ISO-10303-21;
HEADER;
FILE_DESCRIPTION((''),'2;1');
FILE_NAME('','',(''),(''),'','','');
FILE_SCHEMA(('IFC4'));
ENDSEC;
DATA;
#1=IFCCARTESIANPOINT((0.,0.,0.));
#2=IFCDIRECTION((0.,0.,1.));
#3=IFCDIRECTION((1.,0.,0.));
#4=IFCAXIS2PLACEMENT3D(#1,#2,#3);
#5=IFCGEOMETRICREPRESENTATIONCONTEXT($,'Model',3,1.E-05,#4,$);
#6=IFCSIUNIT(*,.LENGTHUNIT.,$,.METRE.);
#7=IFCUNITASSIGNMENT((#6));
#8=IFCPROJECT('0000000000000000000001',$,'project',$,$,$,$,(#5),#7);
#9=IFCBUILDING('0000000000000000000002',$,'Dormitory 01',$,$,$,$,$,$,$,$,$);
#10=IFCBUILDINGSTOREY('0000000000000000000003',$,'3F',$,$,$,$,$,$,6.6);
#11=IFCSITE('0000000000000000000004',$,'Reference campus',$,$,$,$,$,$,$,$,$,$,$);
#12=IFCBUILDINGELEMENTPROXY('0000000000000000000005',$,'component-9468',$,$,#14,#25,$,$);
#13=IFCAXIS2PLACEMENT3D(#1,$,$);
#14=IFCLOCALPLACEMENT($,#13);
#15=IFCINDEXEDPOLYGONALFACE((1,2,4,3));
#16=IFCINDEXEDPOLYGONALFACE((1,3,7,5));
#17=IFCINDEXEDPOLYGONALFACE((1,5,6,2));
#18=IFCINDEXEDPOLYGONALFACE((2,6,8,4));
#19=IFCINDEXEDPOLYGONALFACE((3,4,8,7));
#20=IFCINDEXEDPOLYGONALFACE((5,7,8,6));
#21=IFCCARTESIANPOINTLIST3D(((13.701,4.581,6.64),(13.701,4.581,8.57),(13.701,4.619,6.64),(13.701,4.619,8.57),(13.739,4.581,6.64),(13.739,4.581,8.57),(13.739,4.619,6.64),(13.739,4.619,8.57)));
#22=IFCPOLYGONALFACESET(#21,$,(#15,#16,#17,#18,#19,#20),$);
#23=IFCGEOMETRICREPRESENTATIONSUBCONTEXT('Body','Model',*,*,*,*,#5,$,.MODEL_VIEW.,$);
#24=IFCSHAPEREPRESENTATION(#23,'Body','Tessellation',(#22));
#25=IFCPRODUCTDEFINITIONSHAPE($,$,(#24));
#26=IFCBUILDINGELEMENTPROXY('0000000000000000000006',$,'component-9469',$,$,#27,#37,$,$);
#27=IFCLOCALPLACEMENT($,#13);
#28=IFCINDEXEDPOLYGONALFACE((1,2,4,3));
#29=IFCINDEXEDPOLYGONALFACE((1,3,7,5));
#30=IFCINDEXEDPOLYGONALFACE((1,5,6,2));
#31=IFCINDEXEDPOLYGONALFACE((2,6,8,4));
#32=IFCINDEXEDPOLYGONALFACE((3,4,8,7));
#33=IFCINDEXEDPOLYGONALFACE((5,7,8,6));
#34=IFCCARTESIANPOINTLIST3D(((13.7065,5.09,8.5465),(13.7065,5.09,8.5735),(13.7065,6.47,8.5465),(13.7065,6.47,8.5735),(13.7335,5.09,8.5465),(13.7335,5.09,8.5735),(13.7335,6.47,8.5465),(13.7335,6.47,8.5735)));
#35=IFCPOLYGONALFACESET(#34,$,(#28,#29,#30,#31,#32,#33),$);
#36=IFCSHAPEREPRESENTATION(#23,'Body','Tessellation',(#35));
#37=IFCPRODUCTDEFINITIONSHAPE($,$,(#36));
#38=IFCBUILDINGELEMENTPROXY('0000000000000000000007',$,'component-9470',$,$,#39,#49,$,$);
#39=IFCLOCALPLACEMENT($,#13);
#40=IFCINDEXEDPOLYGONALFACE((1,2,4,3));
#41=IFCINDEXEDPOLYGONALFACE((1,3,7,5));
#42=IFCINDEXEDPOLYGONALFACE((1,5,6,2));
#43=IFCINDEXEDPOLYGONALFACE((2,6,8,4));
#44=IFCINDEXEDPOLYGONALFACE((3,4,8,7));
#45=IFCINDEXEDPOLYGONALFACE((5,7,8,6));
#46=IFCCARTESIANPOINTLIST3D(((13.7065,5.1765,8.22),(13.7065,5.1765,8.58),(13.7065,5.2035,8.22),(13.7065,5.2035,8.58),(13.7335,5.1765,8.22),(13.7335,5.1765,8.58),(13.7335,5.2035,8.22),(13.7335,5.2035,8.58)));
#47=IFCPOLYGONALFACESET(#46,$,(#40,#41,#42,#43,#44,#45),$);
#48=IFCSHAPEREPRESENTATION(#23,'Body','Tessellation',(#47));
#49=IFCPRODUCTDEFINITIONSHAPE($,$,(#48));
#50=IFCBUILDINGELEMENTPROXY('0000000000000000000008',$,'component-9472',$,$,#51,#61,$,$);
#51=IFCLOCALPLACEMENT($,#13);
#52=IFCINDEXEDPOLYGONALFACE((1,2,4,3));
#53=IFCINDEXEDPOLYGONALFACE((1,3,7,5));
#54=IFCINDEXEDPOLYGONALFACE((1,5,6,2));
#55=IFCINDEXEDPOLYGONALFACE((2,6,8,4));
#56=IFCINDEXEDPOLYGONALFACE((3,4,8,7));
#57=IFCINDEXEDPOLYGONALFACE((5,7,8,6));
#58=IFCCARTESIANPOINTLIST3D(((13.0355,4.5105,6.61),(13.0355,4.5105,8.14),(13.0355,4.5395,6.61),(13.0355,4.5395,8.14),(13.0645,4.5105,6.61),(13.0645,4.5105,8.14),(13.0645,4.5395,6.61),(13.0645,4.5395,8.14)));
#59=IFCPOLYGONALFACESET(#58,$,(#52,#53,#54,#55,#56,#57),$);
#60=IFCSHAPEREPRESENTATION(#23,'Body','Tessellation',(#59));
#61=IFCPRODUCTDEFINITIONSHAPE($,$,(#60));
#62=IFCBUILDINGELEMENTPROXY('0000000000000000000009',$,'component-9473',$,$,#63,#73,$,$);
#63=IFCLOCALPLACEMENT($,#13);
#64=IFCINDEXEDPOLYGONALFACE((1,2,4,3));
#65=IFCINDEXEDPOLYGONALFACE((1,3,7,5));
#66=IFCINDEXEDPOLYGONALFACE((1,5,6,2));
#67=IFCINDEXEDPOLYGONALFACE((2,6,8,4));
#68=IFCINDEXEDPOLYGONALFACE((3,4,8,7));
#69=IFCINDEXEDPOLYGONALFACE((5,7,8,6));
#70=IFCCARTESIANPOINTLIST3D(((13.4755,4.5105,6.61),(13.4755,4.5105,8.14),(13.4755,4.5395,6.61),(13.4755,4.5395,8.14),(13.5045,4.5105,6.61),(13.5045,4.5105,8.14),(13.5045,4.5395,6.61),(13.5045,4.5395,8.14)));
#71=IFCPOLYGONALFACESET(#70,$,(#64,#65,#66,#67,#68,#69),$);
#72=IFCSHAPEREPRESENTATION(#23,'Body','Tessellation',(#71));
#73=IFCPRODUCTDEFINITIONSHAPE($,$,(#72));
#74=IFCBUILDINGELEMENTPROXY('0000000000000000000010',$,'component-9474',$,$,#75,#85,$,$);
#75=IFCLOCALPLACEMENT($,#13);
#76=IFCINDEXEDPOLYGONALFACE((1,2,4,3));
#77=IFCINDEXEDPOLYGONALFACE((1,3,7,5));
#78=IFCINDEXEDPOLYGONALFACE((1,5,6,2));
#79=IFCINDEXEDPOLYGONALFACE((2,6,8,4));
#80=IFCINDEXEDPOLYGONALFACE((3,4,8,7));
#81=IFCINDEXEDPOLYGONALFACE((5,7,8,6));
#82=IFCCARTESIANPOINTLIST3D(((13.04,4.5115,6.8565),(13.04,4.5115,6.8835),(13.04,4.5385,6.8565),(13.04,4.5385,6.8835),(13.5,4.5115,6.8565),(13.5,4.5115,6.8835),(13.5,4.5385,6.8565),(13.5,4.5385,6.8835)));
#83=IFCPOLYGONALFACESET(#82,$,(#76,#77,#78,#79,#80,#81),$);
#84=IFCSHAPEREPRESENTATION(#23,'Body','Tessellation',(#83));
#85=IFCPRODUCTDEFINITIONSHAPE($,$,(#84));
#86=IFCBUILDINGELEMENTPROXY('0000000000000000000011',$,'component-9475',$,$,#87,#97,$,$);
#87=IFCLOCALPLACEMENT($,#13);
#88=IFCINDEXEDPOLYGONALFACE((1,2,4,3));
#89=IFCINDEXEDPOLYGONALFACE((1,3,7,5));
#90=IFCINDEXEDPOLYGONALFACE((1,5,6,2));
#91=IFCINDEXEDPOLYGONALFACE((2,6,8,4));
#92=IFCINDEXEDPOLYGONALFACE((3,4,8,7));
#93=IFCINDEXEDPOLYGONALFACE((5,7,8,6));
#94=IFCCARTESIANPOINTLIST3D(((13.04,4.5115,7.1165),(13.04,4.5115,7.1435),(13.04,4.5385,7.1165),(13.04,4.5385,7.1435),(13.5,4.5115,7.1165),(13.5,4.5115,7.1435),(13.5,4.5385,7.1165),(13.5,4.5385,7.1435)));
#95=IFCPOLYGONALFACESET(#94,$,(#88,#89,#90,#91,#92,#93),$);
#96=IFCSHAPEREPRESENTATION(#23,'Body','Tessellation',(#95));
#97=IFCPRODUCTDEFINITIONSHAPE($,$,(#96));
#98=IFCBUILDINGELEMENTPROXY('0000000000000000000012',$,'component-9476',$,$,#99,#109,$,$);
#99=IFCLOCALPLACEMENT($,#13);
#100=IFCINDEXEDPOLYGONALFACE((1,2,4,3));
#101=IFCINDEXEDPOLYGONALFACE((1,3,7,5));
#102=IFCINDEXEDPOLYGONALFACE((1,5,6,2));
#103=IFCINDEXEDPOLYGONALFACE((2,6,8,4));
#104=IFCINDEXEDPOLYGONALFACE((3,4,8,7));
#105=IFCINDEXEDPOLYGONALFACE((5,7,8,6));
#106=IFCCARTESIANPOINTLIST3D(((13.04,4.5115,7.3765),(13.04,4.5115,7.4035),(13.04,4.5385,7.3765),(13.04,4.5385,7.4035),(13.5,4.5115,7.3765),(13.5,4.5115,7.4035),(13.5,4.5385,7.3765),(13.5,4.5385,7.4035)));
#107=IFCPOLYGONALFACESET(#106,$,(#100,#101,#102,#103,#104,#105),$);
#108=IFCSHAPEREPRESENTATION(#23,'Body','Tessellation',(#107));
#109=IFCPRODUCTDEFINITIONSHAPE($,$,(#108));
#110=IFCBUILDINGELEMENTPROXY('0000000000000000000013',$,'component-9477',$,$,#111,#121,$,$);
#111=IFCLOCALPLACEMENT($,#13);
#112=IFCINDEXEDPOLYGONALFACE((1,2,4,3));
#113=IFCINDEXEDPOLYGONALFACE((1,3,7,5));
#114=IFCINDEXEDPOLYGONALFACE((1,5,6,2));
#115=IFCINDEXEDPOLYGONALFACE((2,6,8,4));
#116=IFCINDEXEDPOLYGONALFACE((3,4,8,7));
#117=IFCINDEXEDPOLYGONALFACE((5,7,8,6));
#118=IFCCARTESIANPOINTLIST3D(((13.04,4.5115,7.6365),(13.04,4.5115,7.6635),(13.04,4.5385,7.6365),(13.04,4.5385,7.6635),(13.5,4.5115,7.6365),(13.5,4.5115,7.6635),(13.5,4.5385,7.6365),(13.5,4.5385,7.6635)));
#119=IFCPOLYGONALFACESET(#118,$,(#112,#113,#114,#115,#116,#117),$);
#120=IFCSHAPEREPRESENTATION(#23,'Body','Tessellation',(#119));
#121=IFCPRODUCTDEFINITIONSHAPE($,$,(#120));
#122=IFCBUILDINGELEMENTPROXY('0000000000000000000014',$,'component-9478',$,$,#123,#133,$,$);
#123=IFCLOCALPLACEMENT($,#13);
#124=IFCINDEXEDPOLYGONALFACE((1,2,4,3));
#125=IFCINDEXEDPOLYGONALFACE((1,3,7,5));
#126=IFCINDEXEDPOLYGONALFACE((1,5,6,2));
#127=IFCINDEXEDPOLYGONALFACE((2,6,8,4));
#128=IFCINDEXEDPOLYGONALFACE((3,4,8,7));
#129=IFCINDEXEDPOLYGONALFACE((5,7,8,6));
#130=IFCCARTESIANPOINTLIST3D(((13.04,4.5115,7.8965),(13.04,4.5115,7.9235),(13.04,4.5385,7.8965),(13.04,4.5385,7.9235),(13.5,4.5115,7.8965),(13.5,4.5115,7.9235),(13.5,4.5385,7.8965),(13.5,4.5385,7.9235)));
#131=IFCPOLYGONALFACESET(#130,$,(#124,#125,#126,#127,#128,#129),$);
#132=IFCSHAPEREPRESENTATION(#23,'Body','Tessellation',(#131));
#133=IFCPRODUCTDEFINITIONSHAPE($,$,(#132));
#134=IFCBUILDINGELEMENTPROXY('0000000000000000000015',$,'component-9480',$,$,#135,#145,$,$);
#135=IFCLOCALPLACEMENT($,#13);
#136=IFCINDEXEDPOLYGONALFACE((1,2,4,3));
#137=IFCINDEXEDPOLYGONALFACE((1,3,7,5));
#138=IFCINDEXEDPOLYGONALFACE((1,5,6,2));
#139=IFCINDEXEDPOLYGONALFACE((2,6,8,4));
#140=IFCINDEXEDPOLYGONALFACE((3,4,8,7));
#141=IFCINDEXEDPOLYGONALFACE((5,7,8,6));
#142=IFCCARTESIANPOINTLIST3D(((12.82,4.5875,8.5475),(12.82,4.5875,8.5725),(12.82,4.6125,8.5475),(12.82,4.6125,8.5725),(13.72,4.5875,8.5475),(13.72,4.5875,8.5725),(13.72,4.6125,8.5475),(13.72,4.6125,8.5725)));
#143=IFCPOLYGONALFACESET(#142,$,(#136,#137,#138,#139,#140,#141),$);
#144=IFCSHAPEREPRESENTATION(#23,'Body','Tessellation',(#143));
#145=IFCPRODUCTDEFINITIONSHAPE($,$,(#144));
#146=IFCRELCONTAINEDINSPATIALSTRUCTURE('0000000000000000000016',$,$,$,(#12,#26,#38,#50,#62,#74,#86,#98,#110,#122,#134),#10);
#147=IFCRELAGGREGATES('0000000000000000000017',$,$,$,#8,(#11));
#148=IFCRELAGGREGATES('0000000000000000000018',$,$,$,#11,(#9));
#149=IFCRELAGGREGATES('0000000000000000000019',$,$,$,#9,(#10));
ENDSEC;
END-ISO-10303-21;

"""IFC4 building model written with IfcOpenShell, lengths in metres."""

from ifc_helpers import new_model, si_unit, frame, origin, origin_with_axes, origin_2d, place, context, subcontext, project, spatial, rectangle, extrude, element, save


model = new_model("IFC4")

# Units and contexts
model_context = context("Model", 3, precision=1e-05, world=origin_with_axes())
body_context = subcontext(model_context, "Body", "Model", "MODEL_VIEW")
ifc_project = project(units=[si_unit("LENGTHUNIT", "METRE")], contexts=[model_context])

# Site, building, storey
site = spatial("IfcSite", under=ifc_project, Name="Reference campus")
building = spatial("IfcBuilding", under=site, Name="Dormitory 01")
storey = spatial("IfcBuildingStorey", under=building, Name="3F", Elevation=6.6)

# Building element proxies
proxy_1_placement = place(None, frame((13.72, 4.6, 6.64), z_axis=(0.0, 0.0, 1.0), x_axis=(1.0, 0.0, 0.0)))
element("IfcBuildingElementProxy", 1, at=proxy_1_placement, inside=storey, Name="component-9468", context=body_context, shape_type="SweptSolid", body=[
    extrude(rectangle(XDim=0.038, YDim=0.038, at=origin_2d()), origin(), (0.0, 0.0, 1.0), 1.93),
])
proxy_2_placement = place(None, frame((13.72, 5.78, 8.5465), z_axis=(0.0, 0.0, 1.0), x_axis=(1.0, 0.0, 0.0)))
element("IfcBuildingElementProxy", 2, at=proxy_2_placement, inside=storey, Name="component-9469", context=body_context, shape_type="SweptSolid", body=[
    extrude(rectangle(XDim=0.027, YDim=1.38, at=origin_2d()), origin(), (0.0, 0.0, 1.0), 0.027),
])
proxy_3_placement = place(None, frame((13.72, 5.19, 8.22), z_axis=(0.0, 0.0, 1.0), x_axis=(1.0, 0.0, 0.0)))
element("IfcBuildingElementProxy", 3, at=proxy_3_placement, inside=storey, Name="component-9470", context=body_context, shape_type="SweptSolid", body=[
    extrude(rectangle(XDim=0.027, YDim=0.027, at=origin_2d()), origin(), (0.0, 0.0, 1.0), 0.36),
])
for number, where, z_axis, x_axis, name in (
    (4, (13.05, 4.525, 6.61), (0.0, 0.0, 1.0), (1.0, 0.0, 0.0), "component-9472"),
    (5, (13.49, 4.525, 6.61), (0.0, 0.0, 1.0), (1.0, 0.0, 0.0), "component-9473"),
):
    element("IfcBuildingElementProxy", number, at=place(None, frame(where, z_axis=z_axis, x_axis=x_axis)), inside=storey, Name=name, context=body_context, shape_type="SweptSolid", body=[
        extrude(rectangle(XDim=0.029, YDim=0.029, at=origin_2d()), origin(), (0.0, 0.0, 1.0), 1.53),
    ])
for number, where, z_axis, x_axis, name in (
    (6, (13.27, 4.525, 6.8565), (0.0, 0.0, 1.0), (1.0, 0.0, 0.0), "component-9474"),
    (7, (13.27, 4.525, 7.1165), (0.0, 0.0, 1.0), (1.0, 0.0, 0.0), "component-9475"),
    (8, (13.27, 4.525, 7.3765), (0.0, 0.0, 1.0), (1.0, 0.0, 0.0), "component-9476"),
    (9, (13.27, 4.525, 7.6365), (0.0, 0.0, 1.0), (1.0, 0.0, 0.0), "component-9477"),
    (10, (13.27, 4.525, 7.8965), (0.0, 0.0, 1.0), (1.0, 0.0, 0.0), "component-9478"),
):
    element("IfcBuildingElementProxy", number, at=place(None, frame(where, z_axis=z_axis, x_axis=x_axis)), inside=storey, Name=name, context=body_context, shape_type="SweptSolid", body=[
        extrude(rectangle(XDim=0.46, YDim=0.027, at=origin_2d()), origin(), (0.0, 0.0, 1.0), 0.027),
    ])
proxy_4_placement = place(None, frame((13.27, 4.6, 8.5475), z_axis=(0.0, 0.0, 1.0), x_axis=(1.0, 0.0, 0.0)))
element("IfcBuildingElementProxy", 11, at=proxy_4_placement, inside=storey, Name="component-9480", context=body_context, shape_type="SweptSolid", body=[
    extrude(rectangle(XDim=0.9, YDim=0.025, at=origin_2d()), origin(), (0.0, 0.0, 1.0), 0.025),
])

save(model, "model.ifc")
